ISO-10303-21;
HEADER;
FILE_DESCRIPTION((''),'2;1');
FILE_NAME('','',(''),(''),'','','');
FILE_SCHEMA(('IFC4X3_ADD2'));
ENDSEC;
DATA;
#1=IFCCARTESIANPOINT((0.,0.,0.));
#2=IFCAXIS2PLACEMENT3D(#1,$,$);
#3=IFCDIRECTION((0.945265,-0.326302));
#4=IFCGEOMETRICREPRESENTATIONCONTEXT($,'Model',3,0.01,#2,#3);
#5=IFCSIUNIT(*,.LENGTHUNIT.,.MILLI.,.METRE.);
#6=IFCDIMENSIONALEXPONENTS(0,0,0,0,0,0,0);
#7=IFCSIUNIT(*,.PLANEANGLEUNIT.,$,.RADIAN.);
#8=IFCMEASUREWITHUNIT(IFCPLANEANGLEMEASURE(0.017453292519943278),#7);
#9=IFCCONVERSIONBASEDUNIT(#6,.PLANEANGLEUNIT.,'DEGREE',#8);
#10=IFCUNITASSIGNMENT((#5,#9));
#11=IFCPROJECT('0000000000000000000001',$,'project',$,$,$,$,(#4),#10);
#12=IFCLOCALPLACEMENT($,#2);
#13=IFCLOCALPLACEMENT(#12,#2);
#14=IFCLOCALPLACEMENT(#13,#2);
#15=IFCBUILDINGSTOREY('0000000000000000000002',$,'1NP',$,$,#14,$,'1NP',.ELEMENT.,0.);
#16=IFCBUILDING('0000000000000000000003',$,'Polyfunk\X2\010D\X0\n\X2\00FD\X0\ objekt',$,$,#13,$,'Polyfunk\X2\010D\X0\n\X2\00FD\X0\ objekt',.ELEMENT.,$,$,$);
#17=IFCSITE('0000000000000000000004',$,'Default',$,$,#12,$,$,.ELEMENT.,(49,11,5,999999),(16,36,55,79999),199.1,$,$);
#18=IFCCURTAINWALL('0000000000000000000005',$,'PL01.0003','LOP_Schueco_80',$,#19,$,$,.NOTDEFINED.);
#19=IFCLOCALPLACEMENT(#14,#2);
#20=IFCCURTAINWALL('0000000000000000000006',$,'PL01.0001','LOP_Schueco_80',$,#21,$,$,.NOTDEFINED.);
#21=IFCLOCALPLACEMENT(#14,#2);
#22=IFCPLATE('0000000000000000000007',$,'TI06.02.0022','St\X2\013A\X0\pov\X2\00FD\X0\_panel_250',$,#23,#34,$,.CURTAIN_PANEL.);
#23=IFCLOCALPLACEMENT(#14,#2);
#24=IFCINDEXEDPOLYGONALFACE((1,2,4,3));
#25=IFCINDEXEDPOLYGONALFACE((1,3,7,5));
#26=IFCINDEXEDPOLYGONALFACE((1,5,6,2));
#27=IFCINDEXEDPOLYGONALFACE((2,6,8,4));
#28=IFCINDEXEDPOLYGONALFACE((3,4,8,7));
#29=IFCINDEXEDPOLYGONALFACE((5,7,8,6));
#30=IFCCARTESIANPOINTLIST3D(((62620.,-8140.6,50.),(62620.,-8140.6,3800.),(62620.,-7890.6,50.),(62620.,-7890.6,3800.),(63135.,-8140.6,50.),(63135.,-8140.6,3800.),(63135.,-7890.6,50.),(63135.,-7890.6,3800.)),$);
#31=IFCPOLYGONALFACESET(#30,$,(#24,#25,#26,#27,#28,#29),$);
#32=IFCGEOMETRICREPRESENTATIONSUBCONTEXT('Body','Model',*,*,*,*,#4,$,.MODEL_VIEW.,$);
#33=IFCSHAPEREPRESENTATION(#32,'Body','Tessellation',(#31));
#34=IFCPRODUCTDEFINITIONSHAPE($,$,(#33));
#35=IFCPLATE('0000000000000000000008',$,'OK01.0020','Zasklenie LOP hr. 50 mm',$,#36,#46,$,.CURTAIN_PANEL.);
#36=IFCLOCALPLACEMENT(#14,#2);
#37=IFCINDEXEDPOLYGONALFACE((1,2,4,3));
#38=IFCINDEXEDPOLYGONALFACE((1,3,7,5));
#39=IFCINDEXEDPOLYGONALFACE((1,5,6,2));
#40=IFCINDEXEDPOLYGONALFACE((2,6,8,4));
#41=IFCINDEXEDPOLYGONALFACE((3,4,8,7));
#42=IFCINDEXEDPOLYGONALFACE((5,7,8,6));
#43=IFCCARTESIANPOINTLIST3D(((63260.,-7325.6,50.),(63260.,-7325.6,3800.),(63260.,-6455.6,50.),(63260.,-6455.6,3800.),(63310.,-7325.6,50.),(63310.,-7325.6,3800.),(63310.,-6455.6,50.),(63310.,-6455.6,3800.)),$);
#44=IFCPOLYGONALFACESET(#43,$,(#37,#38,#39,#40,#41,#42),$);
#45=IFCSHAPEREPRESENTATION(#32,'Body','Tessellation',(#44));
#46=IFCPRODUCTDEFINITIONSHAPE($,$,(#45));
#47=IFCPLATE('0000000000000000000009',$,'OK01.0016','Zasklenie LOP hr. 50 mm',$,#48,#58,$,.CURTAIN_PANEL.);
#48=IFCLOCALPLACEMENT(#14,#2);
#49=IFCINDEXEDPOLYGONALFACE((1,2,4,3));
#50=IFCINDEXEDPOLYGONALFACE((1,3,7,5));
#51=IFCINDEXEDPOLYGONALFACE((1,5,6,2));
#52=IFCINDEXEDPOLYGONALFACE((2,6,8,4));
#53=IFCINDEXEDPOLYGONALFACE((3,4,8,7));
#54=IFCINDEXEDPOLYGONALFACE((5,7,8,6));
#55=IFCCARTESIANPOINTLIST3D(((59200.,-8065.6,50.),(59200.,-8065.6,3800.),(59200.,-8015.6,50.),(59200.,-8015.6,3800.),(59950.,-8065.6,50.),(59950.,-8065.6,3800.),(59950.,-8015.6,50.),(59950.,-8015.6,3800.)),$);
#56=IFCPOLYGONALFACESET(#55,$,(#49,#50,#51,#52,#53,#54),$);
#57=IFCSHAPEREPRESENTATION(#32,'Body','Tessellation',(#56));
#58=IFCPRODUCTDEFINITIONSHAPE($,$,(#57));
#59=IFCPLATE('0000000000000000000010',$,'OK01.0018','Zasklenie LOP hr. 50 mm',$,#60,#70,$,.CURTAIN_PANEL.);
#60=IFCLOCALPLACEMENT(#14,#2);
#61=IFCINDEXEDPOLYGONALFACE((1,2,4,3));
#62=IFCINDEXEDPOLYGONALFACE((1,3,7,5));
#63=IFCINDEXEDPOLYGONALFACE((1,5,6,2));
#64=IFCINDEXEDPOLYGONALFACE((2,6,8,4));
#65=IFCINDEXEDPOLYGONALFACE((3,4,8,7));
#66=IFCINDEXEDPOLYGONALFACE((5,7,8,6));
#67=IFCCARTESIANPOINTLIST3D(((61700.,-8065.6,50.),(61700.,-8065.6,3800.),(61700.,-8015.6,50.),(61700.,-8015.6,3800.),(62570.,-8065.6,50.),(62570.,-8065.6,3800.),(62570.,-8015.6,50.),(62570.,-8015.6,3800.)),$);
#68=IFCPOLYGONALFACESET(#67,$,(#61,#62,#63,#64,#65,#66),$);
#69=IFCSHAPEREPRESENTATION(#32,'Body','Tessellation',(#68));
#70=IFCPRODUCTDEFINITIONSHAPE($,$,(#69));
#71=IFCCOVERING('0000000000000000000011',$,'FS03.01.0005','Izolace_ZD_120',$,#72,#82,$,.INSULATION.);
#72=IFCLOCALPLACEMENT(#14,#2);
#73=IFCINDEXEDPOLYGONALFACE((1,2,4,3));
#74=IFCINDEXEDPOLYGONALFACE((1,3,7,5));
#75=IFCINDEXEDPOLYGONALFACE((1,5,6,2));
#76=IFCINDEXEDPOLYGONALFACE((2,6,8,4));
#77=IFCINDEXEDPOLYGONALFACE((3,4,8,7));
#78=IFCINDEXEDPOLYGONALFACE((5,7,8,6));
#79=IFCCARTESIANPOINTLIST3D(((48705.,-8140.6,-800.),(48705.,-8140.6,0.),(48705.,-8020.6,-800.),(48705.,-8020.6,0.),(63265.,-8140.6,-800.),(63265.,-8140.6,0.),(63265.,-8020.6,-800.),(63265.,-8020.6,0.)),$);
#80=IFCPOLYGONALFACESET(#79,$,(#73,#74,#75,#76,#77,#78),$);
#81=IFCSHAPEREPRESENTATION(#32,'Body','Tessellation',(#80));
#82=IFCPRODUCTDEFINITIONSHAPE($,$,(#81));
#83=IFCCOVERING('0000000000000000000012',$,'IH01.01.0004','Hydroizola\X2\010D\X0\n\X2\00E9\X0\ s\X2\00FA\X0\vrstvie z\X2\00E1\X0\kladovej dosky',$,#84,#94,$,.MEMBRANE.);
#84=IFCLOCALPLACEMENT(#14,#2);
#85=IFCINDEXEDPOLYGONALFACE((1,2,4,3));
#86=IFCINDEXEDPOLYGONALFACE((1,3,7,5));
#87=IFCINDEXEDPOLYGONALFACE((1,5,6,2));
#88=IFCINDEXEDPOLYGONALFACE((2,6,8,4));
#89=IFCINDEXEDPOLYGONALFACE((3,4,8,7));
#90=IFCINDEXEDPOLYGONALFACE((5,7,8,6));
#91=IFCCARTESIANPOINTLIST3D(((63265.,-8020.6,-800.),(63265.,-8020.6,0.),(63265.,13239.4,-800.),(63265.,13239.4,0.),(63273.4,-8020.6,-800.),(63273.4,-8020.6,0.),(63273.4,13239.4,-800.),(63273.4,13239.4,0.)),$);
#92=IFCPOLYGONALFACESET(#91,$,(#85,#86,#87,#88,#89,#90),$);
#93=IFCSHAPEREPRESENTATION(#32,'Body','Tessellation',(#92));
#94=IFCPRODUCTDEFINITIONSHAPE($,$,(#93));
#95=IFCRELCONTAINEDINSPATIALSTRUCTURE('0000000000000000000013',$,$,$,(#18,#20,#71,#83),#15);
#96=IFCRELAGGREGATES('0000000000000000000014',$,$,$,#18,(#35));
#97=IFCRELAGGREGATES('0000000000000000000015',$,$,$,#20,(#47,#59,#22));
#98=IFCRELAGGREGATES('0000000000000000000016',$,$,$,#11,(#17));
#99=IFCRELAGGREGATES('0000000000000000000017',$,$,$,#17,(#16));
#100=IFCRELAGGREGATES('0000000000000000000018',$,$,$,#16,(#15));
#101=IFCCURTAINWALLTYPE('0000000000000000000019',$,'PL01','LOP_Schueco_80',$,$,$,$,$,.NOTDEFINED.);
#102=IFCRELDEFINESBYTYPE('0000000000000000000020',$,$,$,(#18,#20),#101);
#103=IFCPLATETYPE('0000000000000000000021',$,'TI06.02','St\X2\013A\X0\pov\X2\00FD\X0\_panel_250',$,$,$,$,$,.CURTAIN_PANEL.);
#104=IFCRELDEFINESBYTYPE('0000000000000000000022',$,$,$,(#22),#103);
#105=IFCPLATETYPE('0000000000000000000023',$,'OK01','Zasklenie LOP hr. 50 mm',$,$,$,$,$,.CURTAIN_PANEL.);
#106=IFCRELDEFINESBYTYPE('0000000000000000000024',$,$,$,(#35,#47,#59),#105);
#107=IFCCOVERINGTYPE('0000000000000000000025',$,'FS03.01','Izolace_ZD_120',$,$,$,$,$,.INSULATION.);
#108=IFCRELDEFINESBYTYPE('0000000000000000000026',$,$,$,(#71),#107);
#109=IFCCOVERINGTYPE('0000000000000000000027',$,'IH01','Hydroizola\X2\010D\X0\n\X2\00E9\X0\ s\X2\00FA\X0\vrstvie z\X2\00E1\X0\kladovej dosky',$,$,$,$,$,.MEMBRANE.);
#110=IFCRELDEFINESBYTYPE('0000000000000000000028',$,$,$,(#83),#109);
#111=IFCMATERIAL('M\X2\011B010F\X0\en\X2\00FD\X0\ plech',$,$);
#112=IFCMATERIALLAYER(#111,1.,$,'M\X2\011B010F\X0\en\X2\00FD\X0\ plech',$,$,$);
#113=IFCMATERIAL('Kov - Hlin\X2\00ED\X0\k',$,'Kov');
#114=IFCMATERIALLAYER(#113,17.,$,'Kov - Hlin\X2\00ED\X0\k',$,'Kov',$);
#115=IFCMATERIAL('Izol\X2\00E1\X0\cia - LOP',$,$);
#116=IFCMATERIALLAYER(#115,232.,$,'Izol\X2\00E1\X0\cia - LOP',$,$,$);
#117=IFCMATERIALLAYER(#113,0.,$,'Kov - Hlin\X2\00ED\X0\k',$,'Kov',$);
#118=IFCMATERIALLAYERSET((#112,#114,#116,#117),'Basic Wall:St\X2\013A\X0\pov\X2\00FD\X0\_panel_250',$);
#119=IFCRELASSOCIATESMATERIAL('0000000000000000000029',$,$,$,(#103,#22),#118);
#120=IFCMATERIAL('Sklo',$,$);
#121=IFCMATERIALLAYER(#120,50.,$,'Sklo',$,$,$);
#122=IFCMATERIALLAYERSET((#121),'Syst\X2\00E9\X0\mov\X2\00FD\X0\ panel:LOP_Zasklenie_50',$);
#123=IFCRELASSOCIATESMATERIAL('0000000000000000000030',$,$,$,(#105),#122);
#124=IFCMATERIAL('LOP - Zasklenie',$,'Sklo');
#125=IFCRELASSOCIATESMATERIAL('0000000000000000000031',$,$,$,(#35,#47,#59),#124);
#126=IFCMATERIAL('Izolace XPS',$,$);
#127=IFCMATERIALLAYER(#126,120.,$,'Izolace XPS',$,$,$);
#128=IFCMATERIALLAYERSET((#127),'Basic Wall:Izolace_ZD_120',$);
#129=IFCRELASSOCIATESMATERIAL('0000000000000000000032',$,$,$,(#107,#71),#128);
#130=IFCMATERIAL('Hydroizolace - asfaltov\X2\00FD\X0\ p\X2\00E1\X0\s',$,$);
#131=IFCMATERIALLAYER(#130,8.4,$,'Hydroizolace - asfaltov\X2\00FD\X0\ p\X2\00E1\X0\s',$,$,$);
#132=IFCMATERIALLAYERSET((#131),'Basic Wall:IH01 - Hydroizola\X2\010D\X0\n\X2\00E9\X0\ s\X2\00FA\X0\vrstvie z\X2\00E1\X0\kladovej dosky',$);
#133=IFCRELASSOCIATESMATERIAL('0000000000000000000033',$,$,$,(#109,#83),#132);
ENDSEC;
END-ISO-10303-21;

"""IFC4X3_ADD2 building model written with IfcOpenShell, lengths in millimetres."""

from ifc_helpers import new_model, entity, si_unit, converted_unit, direction, frame, frame_2d, origin, origin_2d_with_axis, place, context, subcontext, project, spatial, rectangle, extrude, source, transform, mapped, material, layer, layer_set, layer_usage, type_object, type_shapes, element, aggregate, save


model = new_model("IFC4X3_ADD2")

# Units and contexts
model_context = context("Model", 3, precision=0.01, world=origin(), true_north=direction((0.945265, -0.326302)))
body_context = subcontext(model_context, "Body", "Model", "MODEL_VIEW")
ifc_project = project(units=[si_unit("LENGTHUNIT", "METRE", prefix="MILLI"), converted_unit("PLANEANGLEUNIT", "DEGREE", entity("IfcPlaneAngleMeasure", 0.017453292519943278), si_unit("PLANEANGLEUNIT", "RADIAN"), dimensions=[0, 0, 0, 0, 0, 0, 0])], contexts=[model_context])

# Site, building, storey
site_placement = place(None, origin())
site = spatial("IfcSite", under=ifc_project, at=site_placement, Name="Default", CompositionType="ELEMENT", RefLatitude=(49, 11, 5, 999999), RefLongitude=(16, 36, 55, 79999), RefElevation=199.1)
building_placement = place(site_placement, origin())
building = spatial("IfcBuilding", under=site, at=building_placement, Name="Polyfunkčný objekt", LongName="Polyfunkčný objekt", CompositionType="ELEMENT")
storey_placement = place(building_placement, origin())
storey = spatial("IfcBuildingStorey", under=building, at=storey_placement, Name="1NP", LongName="1NP", CompositionType="ELEMENT", Elevation=0.0)

# Curtain walls
curtain_wall_type = type_object("IfcCurtainWallType", Name="PL01", Description="LOP_Schueco_80", PredefinedType="NOTDEFINED")
curtain_wall_1_placement = place(storey_placement, origin())
curtain_wall_1 = element("IfcCurtainWall", 1, at=curtain_wall_1_placement, inside=storey, type_object=curtain_wall_type, Name="PL01.0003", Description="LOP_Schueco_80", PredefinedType="NOTDEFINED")
curtain_wall_2_placement = place(storey_placement, origin())
curtain_wall_2 = element("IfcCurtainWall", 2, at=curtain_wall_2_placement, inside=storey, type_object=curtain_wall_type, Name="PL01.0001", Description="LOP_Schueco_80", PredefinedType="NOTDEFINED")

# Plates
ifc_material_1 = material(Name="Měďený plech")
ifc_layer_1 = layer(ifc_material_1, 1.0, Name="Měďený plech")
ifc_material_2 = material(Name="Kov - Hliník", Category="Kov")
ifc_layer_2 = layer(ifc_material_2, 17.0, Name="Kov - Hliník", Category="Kov")
ifc_material_3 = material(Name="Izolácia - LOP")
ifc_layer_3 = layer(ifc_material_3, 232.0, Name="Izolácia - LOP")
ifc_layer_4 = layer(ifc_material_2, 0.0, Name="Kov - Hliník", Category="Kov")
ifc_layer_set_1 = layer_set([ifc_layer_1, ifc_layer_2, ifc_layer_3, ifc_layer_4], Name="Basic Wall:Stĺpový_panel_250")
plate_type_1 = type_object("IfcPlateType", Name="TI06.02", Description="Stĺpový_panel_250", PredefinedType="CURTAIN_PANEL", material=ifc_layer_set_1)
ifc_layer_usage_1 = layer_usage(ifc_layer_set_1, "AXIS2", "POSITIVE", -125.0)
plate_1_placement = place(storey_placement, frame((62620.0, -8015.6, 50.0)))
plate_1 = element("IfcPlate", 3, at=plate_1_placement, type_object=plate_type_1, material=ifc_layer_usage_1, Name="TI06.02.0022", Description="Stĺpový_panel_250", PredefinedType="CURTAIN_PANEL", context=body_context, shape_type="SweptSolid", body=[
    extrude(rectangle(XDim=250.0, YDim=515.0, at=origin_2d_with_axis()), frame((257.5, 0.0, 0.0), z_axis=(0.0, 0.0, 1.0), x_axis=(0.0, 1.0, 0.0)), (0.0, 0.0, 1.0), 3750.0),
])
ifc_material_4 = material(Name="LOP - Zasklenie", Category="Sklo")
ifc_material_5 = material(Name="Sklo")
ifc_layer_5 = layer(ifc_material_5, 50.0, Name="Sklo")
ifc_layer_set_2 = layer_set([ifc_layer_5], Name="Systémový panel:LOP_Zasklenie_50")
plate_type_2 = type_object("IfcPlateType", Name="OK01", Description="Zasklenie LOP hr. 50 mm", PredefinedType="CURTAIN_PANEL", material=ifc_layer_set_2)
shared_shape_1 = source(origin(), body_context, "Body", "SweptSolid", [
    extrude(rectangle(XDim=3750.0, YDim=870.0, at=frame_2d((-141.7, 0.0), x_axis=(1.0, 0.0))), frame((0.0, 0.0, 2016.7), z_axis=(0.0, 1.0, 0.0), x_axis=(0.0, 0.0, 1.0)), (0.0, 0.0, 1.0), 50.0),
])
plate_2_placement = place(curtain_wall_1_placement, frame((63260.0, -6890.6, 50.0), z_axis=(0.0, 0.0, 1.0), x_axis=(0.0, -1.0, 0.0)))
plate_2 = element("IfcPlate", 4, at=plate_2_placement, type_object=plate_type_2, material=ifc_material_4, Name="OK01.0020", Description="Zasklenie LOP hr. 50 mm", PredefinedType="CURTAIN_PANEL", context=body_context, shape_type="MappedRepresentation", body=[
    mapped(shared_shape_1, transform((0.0, 0.0, 0.0), scale=1.0)),
])
aggregate(curtain_wall_1, [plate_2])
shared_shape_2 = source(origin(), body_context, "Body", "SweptSolid", [
    extrude(rectangle(XDim=3750.0, YDim=750.0, at=frame_2d((-331.2, 0.0), x_axis=(1.0, 0.0))), frame((0.0, -50.0, 2206.2), z_axis=(0.0, 1.0, 0.0), x_axis=(0.0, 0.0, 1.0)), (0.0, 0.0, 1.0), 50.0),
])
plate_3_placement = place(curtain_wall_2_placement, frame((59575.0, -8015.6, 50.0)))
plate_3 = element("IfcPlate", 5, at=plate_3_placement, type_object=plate_type_2, material=ifc_material_4, Name="OK01.0016", Description="Zasklenie LOP hr. 50 mm", PredefinedType="CURTAIN_PANEL", context=body_context, shape_type="MappedRepresentation", body=[
    mapped(shared_shape_2, transform((0.0, 0.0, 0.0), scale=1.0)),
])
shared_shape_3 = source(origin(), body_context, "Body", "SweptSolid", [
    extrude(rectangle(XDim=3750.0, YDim=870.0, at=frame_2d((-331.2, 0.0), x_axis=(1.0, 0.0))), frame((0.0, -50.0, 2206.2), z_axis=(0.0, 1.0, 0.0), x_axis=(0.0, 0.0, 1.0)), (0.0, 0.0, 1.0), 50.0),
])
type_shapes(plate_type_2, [shared_shape_1, shared_shape_2, shared_shape_3])
plate_4_placement = place(curtain_wall_2_placement, frame((62135.0, -8015.6, 50.0)))
plate_4 = element("IfcPlate", 6, at=plate_4_placement, type_object=plate_type_2, material=ifc_material_4, Name="OK01.0018", Description="Zasklenie LOP hr. 50 mm", PredefinedType="CURTAIN_PANEL", context=body_context, shape_type="MappedRepresentation", body=[
    mapped(shared_shape_3, transform((0.0, 0.0, 0.0), scale=1.0)),
])
aggregate(curtain_wall_2, [plate_3, plate_4, plate_1])

# Coverings
ifc_material_6 = material(Name="Izolace XPS")
ifc_layer_6 = layer(ifc_material_6, 120.0, Name="Izolace XPS")
ifc_layer_set_3 = layer_set([ifc_layer_6], Name="Basic Wall:Izolace_ZD_120")
covering_type_1 = type_object("IfcCoveringType", Name="FS03.01", Description="Izolace_ZD_120", PredefinedType="INSULATION", material=ifc_layer_set_3)
covering_1_placement = place(storey_placement, frame((63265.0, -8080.6, -800.0), z_axis=(0.0, 0.0, 1.0), x_axis=(-1.0, 0.0, 0.0)))
element("IfcCovering", 7, at=covering_1_placement, inside=storey, type_object=covering_type_1, material=ifc_layer_set_3, Name="FS03.01.0005", Description="Izolace_ZD_120", PredefinedType="INSULATION", context=body_context, shape_type="SweptSolid", body=[
    extrude(rectangle(XDim=14560.0, YDim=120.0, at=frame_2d((7280.0, 0.0), x_axis=(-1.0, 0.0))), origin(), (0.0, 0.0, 1.0), 800.0),
])
ifc_material_7 = material(Name="Hydroizolace - asfaltový pás")
ifc_layer_7 = layer(ifc_material_7, 8.4, Name="Hydroizolace - asfaltový pás")
ifc_layer_set_4 = layer_set([ifc_layer_7], Name="Basic Wall:IH01 - Hydroizolačné súvrstvie základovej dosky")
covering_type_2 = type_object("IfcCoveringType", Name="IH01", Description="Hydroizolačné súvrstvie základovej dosky", PredefinedType="MEMBRANE", material=ifc_layer_set_4)
covering_2_placement = place(storey_placement, frame((63269.2, -8020.6, -800.0), z_axis=(0.0, 0.0, 1.0), x_axis=(0.0, 1.0, 0.0)))
element("IfcCovering", 8, at=covering_2_placement, inside=storey, type_object=covering_type_2, material=ifc_layer_set_4, Name="IH01.01.0004", Description="Hydroizolačné súvrstvie základovej dosky", PredefinedType="MEMBRANE", context=body_context, shape_type="SweptSolid", body=[
    extrude(rectangle(XDim=21260.0, YDim=8.4, at=frame_2d((10630.0, 0.0), x_axis=(-1.0, 0.0))), origin(), (0.0, 0.0, 1.0), 800.0),
])

save(model, "model.ifc")
